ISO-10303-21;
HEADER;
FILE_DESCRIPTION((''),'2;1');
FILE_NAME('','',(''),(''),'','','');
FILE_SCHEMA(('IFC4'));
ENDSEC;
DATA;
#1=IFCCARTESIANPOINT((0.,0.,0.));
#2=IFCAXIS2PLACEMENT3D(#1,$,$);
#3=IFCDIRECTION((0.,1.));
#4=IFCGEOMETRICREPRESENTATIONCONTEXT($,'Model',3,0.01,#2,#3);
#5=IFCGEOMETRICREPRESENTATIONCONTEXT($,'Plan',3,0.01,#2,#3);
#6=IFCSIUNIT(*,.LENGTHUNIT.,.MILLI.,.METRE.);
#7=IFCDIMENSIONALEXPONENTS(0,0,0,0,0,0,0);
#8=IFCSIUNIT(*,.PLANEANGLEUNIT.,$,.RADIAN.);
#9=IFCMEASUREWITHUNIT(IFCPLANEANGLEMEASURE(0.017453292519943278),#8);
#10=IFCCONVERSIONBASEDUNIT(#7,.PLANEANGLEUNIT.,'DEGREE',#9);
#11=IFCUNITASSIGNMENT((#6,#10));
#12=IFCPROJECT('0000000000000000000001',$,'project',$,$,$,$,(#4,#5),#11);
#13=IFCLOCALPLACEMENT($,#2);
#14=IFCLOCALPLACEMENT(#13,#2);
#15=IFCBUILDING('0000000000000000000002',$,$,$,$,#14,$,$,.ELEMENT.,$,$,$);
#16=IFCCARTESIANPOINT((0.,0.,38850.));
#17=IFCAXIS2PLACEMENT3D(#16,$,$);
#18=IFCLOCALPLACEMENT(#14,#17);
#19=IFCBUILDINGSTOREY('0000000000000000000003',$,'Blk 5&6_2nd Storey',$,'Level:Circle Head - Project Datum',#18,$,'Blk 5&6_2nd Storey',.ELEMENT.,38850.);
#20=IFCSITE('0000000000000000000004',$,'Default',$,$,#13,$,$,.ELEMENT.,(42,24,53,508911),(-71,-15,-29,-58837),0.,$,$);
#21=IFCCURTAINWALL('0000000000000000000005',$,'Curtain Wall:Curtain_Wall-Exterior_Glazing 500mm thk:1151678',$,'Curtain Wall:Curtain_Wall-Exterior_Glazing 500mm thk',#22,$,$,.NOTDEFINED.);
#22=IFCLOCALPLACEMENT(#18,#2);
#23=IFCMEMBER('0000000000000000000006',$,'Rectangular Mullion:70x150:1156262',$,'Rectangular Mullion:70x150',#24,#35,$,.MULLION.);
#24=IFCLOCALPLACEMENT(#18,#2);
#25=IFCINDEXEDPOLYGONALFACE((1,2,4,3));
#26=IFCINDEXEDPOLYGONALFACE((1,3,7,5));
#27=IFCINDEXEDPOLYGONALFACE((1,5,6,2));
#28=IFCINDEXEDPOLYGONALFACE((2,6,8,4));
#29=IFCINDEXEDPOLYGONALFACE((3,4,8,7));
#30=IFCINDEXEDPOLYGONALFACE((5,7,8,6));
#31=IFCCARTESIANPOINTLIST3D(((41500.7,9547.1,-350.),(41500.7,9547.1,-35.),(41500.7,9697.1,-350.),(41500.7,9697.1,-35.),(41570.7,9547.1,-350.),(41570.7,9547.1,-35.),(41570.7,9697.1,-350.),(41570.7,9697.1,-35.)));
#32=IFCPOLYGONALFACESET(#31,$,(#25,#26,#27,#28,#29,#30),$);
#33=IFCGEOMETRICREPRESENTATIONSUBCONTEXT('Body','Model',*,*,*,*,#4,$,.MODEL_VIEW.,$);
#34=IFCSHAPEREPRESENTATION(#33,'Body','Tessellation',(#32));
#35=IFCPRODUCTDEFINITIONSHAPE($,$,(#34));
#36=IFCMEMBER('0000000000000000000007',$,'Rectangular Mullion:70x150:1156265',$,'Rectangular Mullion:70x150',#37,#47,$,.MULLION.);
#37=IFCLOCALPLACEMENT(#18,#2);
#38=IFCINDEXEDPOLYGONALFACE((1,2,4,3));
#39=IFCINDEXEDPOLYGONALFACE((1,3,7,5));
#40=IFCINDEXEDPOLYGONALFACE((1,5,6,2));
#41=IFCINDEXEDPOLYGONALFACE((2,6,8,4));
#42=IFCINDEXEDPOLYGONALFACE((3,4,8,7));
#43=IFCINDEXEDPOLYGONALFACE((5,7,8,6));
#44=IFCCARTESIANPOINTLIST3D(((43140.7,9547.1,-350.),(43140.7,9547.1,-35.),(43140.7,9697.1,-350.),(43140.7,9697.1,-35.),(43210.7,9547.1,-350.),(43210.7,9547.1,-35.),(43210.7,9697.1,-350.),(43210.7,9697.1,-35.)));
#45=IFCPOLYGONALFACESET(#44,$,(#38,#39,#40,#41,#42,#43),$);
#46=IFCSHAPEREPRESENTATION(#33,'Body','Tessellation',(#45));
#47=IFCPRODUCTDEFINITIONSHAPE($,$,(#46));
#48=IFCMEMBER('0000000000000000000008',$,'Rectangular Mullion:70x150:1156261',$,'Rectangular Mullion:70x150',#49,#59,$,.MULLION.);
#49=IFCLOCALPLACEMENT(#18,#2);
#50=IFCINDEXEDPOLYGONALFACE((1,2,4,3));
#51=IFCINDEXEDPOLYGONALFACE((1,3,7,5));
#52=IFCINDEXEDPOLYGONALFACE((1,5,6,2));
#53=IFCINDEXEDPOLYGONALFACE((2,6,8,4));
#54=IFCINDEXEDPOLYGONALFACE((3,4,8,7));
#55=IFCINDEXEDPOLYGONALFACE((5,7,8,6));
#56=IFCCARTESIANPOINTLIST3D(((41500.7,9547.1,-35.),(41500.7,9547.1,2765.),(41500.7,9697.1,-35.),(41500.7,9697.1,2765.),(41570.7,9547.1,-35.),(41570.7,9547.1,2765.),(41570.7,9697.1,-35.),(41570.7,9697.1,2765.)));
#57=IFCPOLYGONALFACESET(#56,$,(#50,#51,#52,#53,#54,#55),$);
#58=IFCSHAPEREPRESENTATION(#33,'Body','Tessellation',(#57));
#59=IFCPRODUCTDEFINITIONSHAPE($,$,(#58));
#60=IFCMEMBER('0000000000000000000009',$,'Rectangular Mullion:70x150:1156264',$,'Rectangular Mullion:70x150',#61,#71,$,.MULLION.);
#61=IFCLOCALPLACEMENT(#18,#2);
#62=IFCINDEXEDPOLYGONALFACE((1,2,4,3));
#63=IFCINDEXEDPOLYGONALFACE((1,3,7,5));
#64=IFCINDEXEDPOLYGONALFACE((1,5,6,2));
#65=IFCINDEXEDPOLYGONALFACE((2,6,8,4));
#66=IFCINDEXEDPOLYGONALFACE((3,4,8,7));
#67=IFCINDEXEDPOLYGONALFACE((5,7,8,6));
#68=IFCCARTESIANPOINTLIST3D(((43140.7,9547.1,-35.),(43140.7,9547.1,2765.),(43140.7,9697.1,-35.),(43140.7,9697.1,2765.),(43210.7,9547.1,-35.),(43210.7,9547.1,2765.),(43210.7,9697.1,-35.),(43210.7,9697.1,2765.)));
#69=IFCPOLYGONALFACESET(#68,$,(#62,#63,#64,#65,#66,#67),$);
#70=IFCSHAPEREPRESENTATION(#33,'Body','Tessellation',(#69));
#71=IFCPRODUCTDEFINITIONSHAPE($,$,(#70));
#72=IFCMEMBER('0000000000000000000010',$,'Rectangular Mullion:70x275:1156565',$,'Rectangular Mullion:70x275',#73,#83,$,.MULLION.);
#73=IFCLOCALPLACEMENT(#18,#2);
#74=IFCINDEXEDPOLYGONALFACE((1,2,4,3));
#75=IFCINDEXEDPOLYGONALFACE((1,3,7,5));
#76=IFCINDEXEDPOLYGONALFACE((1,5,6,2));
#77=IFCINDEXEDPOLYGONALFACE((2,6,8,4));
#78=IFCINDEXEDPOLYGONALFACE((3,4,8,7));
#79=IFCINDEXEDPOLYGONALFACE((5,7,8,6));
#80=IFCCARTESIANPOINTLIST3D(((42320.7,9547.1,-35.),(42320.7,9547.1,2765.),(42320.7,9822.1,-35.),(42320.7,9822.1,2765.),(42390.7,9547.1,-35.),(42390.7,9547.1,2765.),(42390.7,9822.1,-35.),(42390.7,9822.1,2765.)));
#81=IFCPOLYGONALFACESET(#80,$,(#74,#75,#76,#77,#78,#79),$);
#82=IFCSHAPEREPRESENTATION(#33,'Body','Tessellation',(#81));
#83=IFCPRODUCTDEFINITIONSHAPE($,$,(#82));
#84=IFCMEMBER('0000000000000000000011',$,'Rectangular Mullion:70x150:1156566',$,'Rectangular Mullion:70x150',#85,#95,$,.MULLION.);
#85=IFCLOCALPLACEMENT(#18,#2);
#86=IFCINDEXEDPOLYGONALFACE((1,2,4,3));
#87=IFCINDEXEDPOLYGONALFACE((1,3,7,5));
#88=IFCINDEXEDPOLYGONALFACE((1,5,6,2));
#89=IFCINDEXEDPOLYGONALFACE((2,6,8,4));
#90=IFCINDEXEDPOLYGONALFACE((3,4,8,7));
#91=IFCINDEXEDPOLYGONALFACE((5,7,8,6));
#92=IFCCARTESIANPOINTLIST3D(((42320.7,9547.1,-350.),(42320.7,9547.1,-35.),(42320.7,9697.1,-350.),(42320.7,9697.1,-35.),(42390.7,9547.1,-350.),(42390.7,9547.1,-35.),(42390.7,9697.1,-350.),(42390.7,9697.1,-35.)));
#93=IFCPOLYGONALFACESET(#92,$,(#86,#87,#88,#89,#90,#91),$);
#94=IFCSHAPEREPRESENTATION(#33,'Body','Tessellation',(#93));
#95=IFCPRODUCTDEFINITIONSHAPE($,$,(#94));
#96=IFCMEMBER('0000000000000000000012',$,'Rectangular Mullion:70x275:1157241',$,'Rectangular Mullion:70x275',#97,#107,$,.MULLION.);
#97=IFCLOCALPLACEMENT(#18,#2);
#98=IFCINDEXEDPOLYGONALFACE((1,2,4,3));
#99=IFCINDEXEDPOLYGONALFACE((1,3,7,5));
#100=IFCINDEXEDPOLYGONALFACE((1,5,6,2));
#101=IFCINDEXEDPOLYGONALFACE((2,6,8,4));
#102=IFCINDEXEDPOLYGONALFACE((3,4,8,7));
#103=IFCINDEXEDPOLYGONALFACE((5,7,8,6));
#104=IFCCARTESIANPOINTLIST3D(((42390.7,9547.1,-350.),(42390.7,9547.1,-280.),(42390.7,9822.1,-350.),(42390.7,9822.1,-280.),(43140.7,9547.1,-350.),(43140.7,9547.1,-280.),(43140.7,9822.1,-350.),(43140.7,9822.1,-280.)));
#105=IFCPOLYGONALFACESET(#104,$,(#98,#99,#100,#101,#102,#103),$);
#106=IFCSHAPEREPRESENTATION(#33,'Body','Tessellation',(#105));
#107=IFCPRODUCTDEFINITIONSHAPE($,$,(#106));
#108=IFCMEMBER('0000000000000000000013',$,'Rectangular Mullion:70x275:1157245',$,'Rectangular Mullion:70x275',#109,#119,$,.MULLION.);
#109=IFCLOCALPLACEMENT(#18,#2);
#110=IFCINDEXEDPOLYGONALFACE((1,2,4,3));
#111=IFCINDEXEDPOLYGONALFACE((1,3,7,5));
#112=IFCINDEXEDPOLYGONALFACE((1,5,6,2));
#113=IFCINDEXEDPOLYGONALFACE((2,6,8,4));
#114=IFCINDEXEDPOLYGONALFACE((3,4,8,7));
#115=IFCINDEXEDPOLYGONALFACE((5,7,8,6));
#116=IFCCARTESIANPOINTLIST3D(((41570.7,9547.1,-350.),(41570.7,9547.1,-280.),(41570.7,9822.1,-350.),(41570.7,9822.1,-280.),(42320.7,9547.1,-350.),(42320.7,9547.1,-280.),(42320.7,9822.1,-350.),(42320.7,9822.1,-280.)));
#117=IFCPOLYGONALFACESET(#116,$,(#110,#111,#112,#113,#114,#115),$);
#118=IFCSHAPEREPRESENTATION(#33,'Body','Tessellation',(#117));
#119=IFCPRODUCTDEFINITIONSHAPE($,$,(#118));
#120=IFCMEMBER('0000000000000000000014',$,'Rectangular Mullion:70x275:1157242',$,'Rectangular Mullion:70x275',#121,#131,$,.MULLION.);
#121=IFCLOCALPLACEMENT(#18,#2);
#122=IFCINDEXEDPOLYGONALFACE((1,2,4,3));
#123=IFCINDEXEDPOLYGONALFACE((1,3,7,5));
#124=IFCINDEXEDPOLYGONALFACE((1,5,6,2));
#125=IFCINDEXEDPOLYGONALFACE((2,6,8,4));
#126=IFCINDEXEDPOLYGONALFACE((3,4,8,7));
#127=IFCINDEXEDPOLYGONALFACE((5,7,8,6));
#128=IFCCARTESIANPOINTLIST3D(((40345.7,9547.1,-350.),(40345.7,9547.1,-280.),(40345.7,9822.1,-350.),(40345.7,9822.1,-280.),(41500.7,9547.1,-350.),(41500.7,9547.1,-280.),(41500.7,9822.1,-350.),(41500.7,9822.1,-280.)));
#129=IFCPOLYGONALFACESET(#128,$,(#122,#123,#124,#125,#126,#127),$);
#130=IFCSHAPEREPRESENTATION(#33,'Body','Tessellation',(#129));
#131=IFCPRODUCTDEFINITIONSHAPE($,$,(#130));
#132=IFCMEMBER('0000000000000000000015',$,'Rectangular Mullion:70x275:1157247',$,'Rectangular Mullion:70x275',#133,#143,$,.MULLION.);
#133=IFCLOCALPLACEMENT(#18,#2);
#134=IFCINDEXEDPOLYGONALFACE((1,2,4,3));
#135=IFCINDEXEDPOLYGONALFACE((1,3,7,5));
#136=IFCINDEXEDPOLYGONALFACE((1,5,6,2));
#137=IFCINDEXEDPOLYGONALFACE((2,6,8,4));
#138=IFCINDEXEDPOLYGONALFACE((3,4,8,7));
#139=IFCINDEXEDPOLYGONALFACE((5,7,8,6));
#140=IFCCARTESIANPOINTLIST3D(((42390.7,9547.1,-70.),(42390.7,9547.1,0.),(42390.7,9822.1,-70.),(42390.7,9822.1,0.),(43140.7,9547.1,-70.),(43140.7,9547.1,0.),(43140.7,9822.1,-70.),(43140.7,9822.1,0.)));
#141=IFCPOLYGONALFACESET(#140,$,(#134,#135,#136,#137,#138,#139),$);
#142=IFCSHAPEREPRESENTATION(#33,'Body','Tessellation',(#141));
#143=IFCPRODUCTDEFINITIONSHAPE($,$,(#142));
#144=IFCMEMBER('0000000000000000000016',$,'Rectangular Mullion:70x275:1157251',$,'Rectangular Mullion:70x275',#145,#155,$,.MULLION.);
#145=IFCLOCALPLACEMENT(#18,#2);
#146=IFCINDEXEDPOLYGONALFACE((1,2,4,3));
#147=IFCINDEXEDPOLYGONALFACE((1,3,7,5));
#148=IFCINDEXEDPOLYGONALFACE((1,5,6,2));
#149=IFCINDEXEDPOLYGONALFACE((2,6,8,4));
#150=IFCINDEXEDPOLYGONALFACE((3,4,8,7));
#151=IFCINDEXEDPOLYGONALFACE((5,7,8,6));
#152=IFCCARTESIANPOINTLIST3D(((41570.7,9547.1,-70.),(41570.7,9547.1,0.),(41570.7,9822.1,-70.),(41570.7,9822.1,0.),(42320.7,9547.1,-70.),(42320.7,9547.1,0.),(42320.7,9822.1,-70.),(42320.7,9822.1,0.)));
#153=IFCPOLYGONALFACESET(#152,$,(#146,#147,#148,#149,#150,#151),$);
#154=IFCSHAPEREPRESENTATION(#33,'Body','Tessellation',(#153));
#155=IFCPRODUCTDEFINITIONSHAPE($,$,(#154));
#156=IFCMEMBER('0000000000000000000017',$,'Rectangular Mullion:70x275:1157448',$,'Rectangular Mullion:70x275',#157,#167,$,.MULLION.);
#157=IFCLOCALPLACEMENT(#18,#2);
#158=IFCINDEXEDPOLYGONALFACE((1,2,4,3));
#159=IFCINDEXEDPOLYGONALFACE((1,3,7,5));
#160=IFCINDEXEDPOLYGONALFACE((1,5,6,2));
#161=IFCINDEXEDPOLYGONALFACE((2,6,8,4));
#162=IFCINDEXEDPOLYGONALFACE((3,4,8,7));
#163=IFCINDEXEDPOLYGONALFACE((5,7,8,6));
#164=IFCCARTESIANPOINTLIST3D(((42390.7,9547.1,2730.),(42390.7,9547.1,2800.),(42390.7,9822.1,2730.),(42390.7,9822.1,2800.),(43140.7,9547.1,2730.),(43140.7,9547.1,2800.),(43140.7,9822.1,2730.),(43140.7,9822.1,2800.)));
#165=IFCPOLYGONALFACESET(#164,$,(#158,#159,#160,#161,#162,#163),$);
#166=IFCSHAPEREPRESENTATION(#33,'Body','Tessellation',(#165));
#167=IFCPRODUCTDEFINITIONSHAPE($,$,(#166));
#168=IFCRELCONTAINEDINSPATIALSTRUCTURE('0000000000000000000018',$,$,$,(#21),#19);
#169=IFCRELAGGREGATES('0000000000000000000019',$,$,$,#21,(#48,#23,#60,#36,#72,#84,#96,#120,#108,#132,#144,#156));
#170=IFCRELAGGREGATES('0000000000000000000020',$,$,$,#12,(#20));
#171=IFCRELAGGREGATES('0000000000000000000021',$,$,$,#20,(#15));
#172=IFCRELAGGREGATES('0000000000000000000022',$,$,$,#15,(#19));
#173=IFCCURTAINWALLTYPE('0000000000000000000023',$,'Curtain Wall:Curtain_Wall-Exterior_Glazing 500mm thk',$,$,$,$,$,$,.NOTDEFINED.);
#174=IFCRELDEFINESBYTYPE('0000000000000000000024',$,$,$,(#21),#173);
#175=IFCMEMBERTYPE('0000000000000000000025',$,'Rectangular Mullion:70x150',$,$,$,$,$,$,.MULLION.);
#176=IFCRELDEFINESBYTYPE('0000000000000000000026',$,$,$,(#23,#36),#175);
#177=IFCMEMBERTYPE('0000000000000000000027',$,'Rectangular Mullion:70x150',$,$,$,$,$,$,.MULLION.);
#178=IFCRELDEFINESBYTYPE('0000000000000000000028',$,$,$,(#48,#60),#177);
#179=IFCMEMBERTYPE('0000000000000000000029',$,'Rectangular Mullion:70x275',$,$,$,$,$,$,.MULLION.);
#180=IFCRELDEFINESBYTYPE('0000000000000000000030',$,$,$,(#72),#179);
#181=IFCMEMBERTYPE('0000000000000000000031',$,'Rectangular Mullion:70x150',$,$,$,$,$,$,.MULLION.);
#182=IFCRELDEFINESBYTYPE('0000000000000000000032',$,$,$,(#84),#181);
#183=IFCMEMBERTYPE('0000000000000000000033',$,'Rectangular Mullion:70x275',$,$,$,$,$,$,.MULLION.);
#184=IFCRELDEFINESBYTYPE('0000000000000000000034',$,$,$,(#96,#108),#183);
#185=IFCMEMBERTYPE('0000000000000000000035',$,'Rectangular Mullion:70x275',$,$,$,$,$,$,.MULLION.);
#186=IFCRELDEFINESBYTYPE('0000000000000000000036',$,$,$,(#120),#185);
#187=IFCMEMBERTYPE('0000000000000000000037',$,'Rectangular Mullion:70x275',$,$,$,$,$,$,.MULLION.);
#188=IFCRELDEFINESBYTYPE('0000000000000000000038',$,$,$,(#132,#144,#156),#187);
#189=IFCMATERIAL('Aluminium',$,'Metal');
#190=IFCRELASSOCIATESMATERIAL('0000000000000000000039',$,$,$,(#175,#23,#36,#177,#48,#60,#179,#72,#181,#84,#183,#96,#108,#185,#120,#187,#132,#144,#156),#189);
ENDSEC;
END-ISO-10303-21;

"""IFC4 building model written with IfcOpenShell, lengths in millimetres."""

from ifc_helpers import new_model, entity, si_unit, converted_unit, direction, frame, origin, place, context, subcontext, project, spatial, indexed_curve, outline, extrude, source, transform, mapped, material, type_object, type_shapes, element, aggregate, save


model = new_model("IFC4")

# Units and contexts
model_context = context("Model", 3, precision=0.01, world=origin(), true_north=direction((0.0, 1.0)))
plan_context = context("Plan", 3, precision=0.01, world=origin(), true_north=direction((0.0, 1.0)))
body_context = subcontext(model_context, "Body", "Model", "MODEL_VIEW")
ifc_project = project(units=[si_unit("LENGTHUNIT", "METRE", prefix="MILLI"), converted_unit("PLANEANGLEUNIT", "DEGREE", entity("IfcPlaneAngleMeasure", 0.017453292519943278), si_unit("PLANEANGLEUNIT", "RADIAN"), dimensions=[0, 0, 0, 0, 0, 0, 0])], contexts=[model_context, plan_context])

# Site, building, storey
site_placement = place(None, origin())
site = spatial("IfcSite", under=ifc_project, at=site_placement, Name="Default", CompositionType="ELEMENT", RefLatitude=(42, 24, 53, 508911), RefLongitude=(-71, -15, -29, -58837), RefElevation=0.0)
building_placement = place(site_placement, origin())
building = spatial("IfcBuilding", under=site, at=building_placement, CompositionType="ELEMENT")
storey_placement = place(building_placement, frame((0.0, 0.0, 38850.0)))
storey = spatial("IfcBuildingStorey", under=building, at=storey_placement, Name="Blk 5&6_2nd Storey", ObjectType="Level:Circle Head - Project Datum", LongName="Blk 5&6_2nd Storey", CompositionType="ELEMENT", Elevation=38850.0)

# Curtain wall, members
curtain_wall_type = type_object("IfcCurtainWallType", Name="Curtain Wall:Curtain_Wall-Exterior_Glazing 500mm thk", PredefinedType="NOTDEFINED")
curtain_wall_placement = place(storey_placement, frame((0.0, 0.0, -38850.0)))
curtain_wall = element("IfcCurtainWall", 1, at=curtain_wall_placement, inside=storey, type_object=curtain_wall_type, Name="Curtain Wall:Curtain_Wall-Exterior_Glazing 500mm thk:1151678", ObjectType="Curtain Wall:Curtain_Wall-Exterior_Glazing 500mm thk", PredefinedType="NOTDEFINED")
ifc_material_1 = material(Name="Aluminium", Category="Metal")
member_type_1 = type_object("IfcMemberType", Name="Rectangular Mullion:70x150", PredefinedType="MULLION", material=ifc_material_1)
shared_shape_1 = source(origin(), body_context, "Body", "SweptSolid", [
    extrude(outline(indexed_curve([(-35.0, -75.0), (35.0, -75.0), (35.0, 75.0), (-35.0, 75.0), (-35.0, -75.0)], self_intersect=False)), frame((0.0, -200.0, -315.0), z_axis=(0.0, 0.0, 1.0), x_axis=(-1.0, 0.0, 0.0)), (0.0, 0.0, 1.0), 315.0),
])
type_shapes(member_type_1, [shared_shape_1])
member_1_placement = place(curtain_wall_placement, frame((41535.7, 9822.1, 38500.0), z_axis=(0.0, 0.0, -1.0), x_axis=(-1.0, 0.0, 0.0)))
member_1 = element("IfcMember", 2, at=member_1_placement, type_object=member_type_1, material=ifc_material_1, Name="Rectangular Mullion:70x150:1156262", ObjectType="Rectangular Mullion:70x150", PredefinedType="MULLION", context=body_context, shape_type="MappedRepresentation", body=[
    mapped(shared_shape_1, transform((0.0, 0.0, 0.0), scale=1.0)),
])
member_2_placement = place(curtain_wall_placement, frame((43175.7, 9822.1, 38500.0), z_axis=(0.0, 0.0, -1.0), x_axis=(-1.0, 0.0, 0.0)))
member_2 = element("IfcMember", 3, at=member_2_placement, type_object=member_type_1, material=ifc_material_1, Name="Rectangular Mullion:70x150:1156265", ObjectType="Rectangular Mullion:70x150", PredefinedType="MULLION", context=body_context, shape_type="MappedRepresentation", body=[
    mapped(shared_shape_1, transform((0.0, 0.0, 0.0), scale=1.0)),
])
member_type_2 = type_object("IfcMemberType", Name="Rectangular Mullion:70x150", PredefinedType="MULLION", material=ifc_material_1)
shared_shape_2 = source(origin(), body_context, "Body", "SweptSolid", [
    extrude(outline(indexed_curve([(-35.0, -75.0), (35.0, -75.0), (35.0, 75.0), (-35.0, 75.0), (-35.0, -75.0)], self_intersect=False)), frame((0.0, -200.0, -2800.0), z_axis=(0.0, 0.0, 1.0), x_axis=(-1.0, 0.0, 0.0)), (0.0, 0.0, 1.0), 2800.0),
])
type_shapes(member_type_2, [shared_shape_2])
member_3_placement = place(curtain_wall_placement, frame((41535.7, 9822.1, 38815.0), z_axis=(0.0, 0.0, -1.0), x_axis=(-1.0, 0.0, 0.0)))
member_3 = element("IfcMember", 4, at=member_3_placement, type_object=member_type_2, material=ifc_material_1, Name="Rectangular Mullion:70x150:1156261", ObjectType="Rectangular Mullion:70x150", PredefinedType="MULLION", context=body_context, shape_type="MappedRepresentation", body=[
    mapped(shared_shape_2, transform((0.0, 0.0, 0.0), scale=1.0)),
])
member_4_placement = place(curtain_wall_placement, frame((43175.7, 9822.1, 38815.0), z_axis=(0.0, 0.0, -1.0), x_axis=(-1.0, 0.0, 0.0)))
member_4 = element("IfcMember", 5, at=member_4_placement, type_object=member_type_2, material=ifc_material_1, Name="Rectangular Mullion:70x150:1156264", ObjectType="Rectangular Mullion:70x150", PredefinedType="MULLION", context=body_context, shape_type="MappedRepresentation", body=[
    mapped(shared_shape_2, transform((0.0, 0.0, 0.0), scale=1.0)),
])
member_type_3 = type_object("IfcMemberType", Name="Rectangular Mullion:70x275", PredefinedType="MULLION", material=ifc_material_1)
shared_shape_3 = source(origin(), body_context, "Body", "SweptSolid", [
    extrude(outline(indexed_curve([(-35.0, -137.5), (35.0, -137.5), (35.0, 137.5), (-35.0, 137.5), (-35.0, -137.5)], self_intersect=False)), frame((0.0, -137.5, -2800.0), z_axis=(0.0, 0.0, 1.0), x_axis=(-1.0, 0.0, 0.0)), (0.0, 0.0, 1.0), 2800.0),
])
type_shapes(member_type_3, [shared_shape_3])
member_5_placement = place(curtain_wall_placement, frame((42355.7, 9822.1, 38815.0), z_axis=(0.0, 0.0, -1.0), x_axis=(-1.0, 0.0, 0.0)))
member_5 = element("IfcMember", 6, at=member_5_placement, type_object=member_type_3, material=ifc_material_1, Name="Rectangular Mullion:70x275:1156565", ObjectType="Rectangular Mullion:70x275", PredefinedType="MULLION", context=body_context, shape_type="MappedRepresentation", body=[
    mapped(shared_shape_3, transform((0.0, 0.0, 0.0), scale=1.0)),
])
member_type_4 = type_object("IfcMemberType", Name="Rectangular Mullion:70x150", PredefinedType="MULLION", material=ifc_material_1)
shared_shape_4 = source(origin(), body_context, "Body", "SweptSolid", [
    extrude(outline(indexed_curve([(-35.0, -75.0), (35.0, -75.0), (35.0, 75.0), (-35.0, 75.0), (-35.0, -75.0)], self_intersect=False)), frame((0.0, -200.0, -315.0), z_axis=(0.0, 0.0, 1.0), x_axis=(-1.0, 0.0, 0.0)), (0.0, 0.0, 1.0), 315.0),
])
type_shapes(member_type_4, [shared_shape_4])
member_6_placement = place(curtain_wall_placement, frame((42355.7, 9822.1, 38500.0), z_axis=(0.0, 0.0, -1.0), x_axis=(-1.0, 0.0, 0.0)))
member_6 = element("IfcMember", 7, at=member_6_placement, type_object=member_type_4, material=ifc_material_1, Name="Rectangular Mullion:70x150:1156566", ObjectType="Rectangular Mullion:70x150", PredefinedType="MULLION", context=body_context, shape_type="MappedRepresentation", body=[
    mapped(shared_shape_4, transform((0.0, 0.0, 0.0), scale=1.0)),
])
member_type_5 = type_object("IfcMemberType", Name="Rectangular Mullion:70x275", PredefinedType="MULLION", material=ifc_material_1)
shared_shape_5 = source(origin(), body_context, "Body", "SweptSolid", [
    extrude(outline(indexed_curve([(-35.0, -137.5), (35.0, -137.5), (35.0, 137.5), (-35.0, 137.5), (-35.0, -137.5)], self_intersect=False)), frame((-35.0, -137.5, -750.0), z_axis=(0.0, 0.0, 1.0), x_axis=(-1.0, 0.0, 0.0)), (0.0, 0.0, 1.0), 750.0),
])
type_shapes(member_type_5, [shared_shape_5])
member_7_placement = place(curtain_wall_placement, frame((43140.7, 9822.1, 38500.0), z_axis=(1.0, 0.0, 0.0), x_axis=(0.0, 0.0, -1.0)))
member_7 = element("IfcMember", 8, at=member_7_placement, type_object=member_type_5, material=ifc_material_1, Name="Rectangular Mullion:70x275:1157241", ObjectType="Rectangular Mullion:70x275", PredefinedType="MULLION", context=body_context, shape_type="MappedRepresentation", body=[
    mapped(shared_shape_5, transform((0.0, 0.0, 0.0), scale=1.0)),
])
member_8_placement = place(curtain_wall_placement, frame((42320.7, 9822.1, 38500.0), z_axis=(1.0, 0.0, 0.0), x_axis=(0.0, 0.0, -1.0)))
member_8 = element("IfcMember", 9, at=member_8_placement, type_object=member_type_5, material=ifc_material_1, Name="Rectangular Mullion:70x275:1157245", ObjectType="Rectangular Mullion:70x275", PredefinedType="MULLION", context=body_context, shape_type="MappedRepresentation", body=[
    mapped(shared_shape_5, transform((0.0, 0.0, 0.0), scale=1.0)),
])
member_type_6 = type_object("IfcMemberType", Name="Rectangular Mullion:70x275", PredefinedType="MULLION", material=ifc_material_1)
shared_shape_6 = source(origin(), body_context, "Body", "SweptSolid", [
    extrude(outline(indexed_curve([(-35.0, -137.5), (35.0, -137.5), (35.0, 137.5), (-35.0, 137.5), (-35.0, -137.5)], self_intersect=False)), frame((-35.0, -137.5, -1155.0), z_axis=(0.0, 0.0, 1.0), x_axis=(-1.0, 0.0, 0.0)), (0.0, 0.0, 1.0), 1155.0),
])
type_shapes(member_type_6, [shared_shape_6])
member_9_placement = place(curtain_wall_placement, frame((41500.7, 9822.1, 38500.0), z_axis=(1.0, 0.0, 0.0), x_axis=(0.0, 0.0, -1.0)))
member_9 = element("IfcMember", 10, at=member_9_placement, type_object=member_type_6, material=ifc_material_1, Name="Rectangular Mullion:70x275:1157242", ObjectType="Rectangular Mullion:70x275", PredefinedType="MULLION", context=body_context, shape_type="MappedRepresentation", body=[
    mapped(shared_shape_6, transform((0.0, 0.0, 0.0), scale=1.0)),
])
member_type_7 = type_object("IfcMemberType", Name="Rectangular Mullion:70x275", PredefinedType="MULLION", material=ifc_material_1)
shared_shape_7 = source(origin(), body_context, "Body", "SweptSolid", [
    extrude(outline(indexed_curve([(-35.0, -137.5), (35.0, -137.5), (35.0, 137.5), (-35.0, 137.5), (-35.0, -137.5)], self_intersect=False)), frame((0.0, -137.5, -750.0), z_axis=(0.0, 0.0, 1.0), x_axis=(-1.0, 0.0, 0.0)), (0.0, 0.0, 1.0), 750.0),
])
type_shapes(member_type_7, [shared_shape_7])
member_10_placement = place(curtain_wall_placement, frame((42390.7, 9822.1, 38815.0), z_axis=(-1.0, 0.0, 0.0), x_axis=(0.0, 0.0, 1.0)))
member_10 = element("IfcMember", 11, at=member_10_placement, type_object=member_type_7, material=ifc_material_1, Name="Rectangular Mullion:70x275:1157247", ObjectType="Rectangular Mullion:70x275", PredefinedType="MULLION", context=body_context, shape_type="MappedRepresentation", body=[
    mapped(shared_shape_7, transform((0.0, 0.0, 0.0), scale=1.0)),
])
member_11_placement = place(curtain_wall_placement, frame((41570.7, 9822.1, 38815.0), z_axis=(-1.0, 0.0, 0.0), x_axis=(0.0, 0.0, 1.0)))
member_11 = element("IfcMember", 12, at=member_11_placement, type_object=member_type_7, material=ifc_material_1, Name="Rectangular Mullion:70x275:1157251", ObjectType="Rectangular Mullion:70x275", PredefinedType="MULLION", context=body_context, shape_type="MappedRepresentation", body=[
    mapped(shared_shape_7, transform((0.0, 0.0, 0.0), scale=1.0)),
])
member_12_placement = place(curtain_wall_placement, frame((42390.7, 9822.1, 41615.0), z_axis=(-1.0, 0.0, 0.0), x_axis=(0.0, 0.0, 1.0)))
member_12 = element("IfcMember", 13, at=member_12_placement, type_object=member_type_7, material=ifc_material_1, Name="Rectangular Mullion:70x275:1157448", ObjectType="Rectangular Mullion:70x275", PredefinedType="MULLION", context=body_context, shape_type="MappedRepresentation", body=[
    mapped(shared_shape_7, transform((0.0, 0.0, 0.0), scale=1.0)),
])
aggregate(curtain_wall, [member_3, member_1, member_4, member_2, member_5, member_6, member_7, member_9, member_8, member_10, member_11, member_12])

save(model, "model.ifc")
